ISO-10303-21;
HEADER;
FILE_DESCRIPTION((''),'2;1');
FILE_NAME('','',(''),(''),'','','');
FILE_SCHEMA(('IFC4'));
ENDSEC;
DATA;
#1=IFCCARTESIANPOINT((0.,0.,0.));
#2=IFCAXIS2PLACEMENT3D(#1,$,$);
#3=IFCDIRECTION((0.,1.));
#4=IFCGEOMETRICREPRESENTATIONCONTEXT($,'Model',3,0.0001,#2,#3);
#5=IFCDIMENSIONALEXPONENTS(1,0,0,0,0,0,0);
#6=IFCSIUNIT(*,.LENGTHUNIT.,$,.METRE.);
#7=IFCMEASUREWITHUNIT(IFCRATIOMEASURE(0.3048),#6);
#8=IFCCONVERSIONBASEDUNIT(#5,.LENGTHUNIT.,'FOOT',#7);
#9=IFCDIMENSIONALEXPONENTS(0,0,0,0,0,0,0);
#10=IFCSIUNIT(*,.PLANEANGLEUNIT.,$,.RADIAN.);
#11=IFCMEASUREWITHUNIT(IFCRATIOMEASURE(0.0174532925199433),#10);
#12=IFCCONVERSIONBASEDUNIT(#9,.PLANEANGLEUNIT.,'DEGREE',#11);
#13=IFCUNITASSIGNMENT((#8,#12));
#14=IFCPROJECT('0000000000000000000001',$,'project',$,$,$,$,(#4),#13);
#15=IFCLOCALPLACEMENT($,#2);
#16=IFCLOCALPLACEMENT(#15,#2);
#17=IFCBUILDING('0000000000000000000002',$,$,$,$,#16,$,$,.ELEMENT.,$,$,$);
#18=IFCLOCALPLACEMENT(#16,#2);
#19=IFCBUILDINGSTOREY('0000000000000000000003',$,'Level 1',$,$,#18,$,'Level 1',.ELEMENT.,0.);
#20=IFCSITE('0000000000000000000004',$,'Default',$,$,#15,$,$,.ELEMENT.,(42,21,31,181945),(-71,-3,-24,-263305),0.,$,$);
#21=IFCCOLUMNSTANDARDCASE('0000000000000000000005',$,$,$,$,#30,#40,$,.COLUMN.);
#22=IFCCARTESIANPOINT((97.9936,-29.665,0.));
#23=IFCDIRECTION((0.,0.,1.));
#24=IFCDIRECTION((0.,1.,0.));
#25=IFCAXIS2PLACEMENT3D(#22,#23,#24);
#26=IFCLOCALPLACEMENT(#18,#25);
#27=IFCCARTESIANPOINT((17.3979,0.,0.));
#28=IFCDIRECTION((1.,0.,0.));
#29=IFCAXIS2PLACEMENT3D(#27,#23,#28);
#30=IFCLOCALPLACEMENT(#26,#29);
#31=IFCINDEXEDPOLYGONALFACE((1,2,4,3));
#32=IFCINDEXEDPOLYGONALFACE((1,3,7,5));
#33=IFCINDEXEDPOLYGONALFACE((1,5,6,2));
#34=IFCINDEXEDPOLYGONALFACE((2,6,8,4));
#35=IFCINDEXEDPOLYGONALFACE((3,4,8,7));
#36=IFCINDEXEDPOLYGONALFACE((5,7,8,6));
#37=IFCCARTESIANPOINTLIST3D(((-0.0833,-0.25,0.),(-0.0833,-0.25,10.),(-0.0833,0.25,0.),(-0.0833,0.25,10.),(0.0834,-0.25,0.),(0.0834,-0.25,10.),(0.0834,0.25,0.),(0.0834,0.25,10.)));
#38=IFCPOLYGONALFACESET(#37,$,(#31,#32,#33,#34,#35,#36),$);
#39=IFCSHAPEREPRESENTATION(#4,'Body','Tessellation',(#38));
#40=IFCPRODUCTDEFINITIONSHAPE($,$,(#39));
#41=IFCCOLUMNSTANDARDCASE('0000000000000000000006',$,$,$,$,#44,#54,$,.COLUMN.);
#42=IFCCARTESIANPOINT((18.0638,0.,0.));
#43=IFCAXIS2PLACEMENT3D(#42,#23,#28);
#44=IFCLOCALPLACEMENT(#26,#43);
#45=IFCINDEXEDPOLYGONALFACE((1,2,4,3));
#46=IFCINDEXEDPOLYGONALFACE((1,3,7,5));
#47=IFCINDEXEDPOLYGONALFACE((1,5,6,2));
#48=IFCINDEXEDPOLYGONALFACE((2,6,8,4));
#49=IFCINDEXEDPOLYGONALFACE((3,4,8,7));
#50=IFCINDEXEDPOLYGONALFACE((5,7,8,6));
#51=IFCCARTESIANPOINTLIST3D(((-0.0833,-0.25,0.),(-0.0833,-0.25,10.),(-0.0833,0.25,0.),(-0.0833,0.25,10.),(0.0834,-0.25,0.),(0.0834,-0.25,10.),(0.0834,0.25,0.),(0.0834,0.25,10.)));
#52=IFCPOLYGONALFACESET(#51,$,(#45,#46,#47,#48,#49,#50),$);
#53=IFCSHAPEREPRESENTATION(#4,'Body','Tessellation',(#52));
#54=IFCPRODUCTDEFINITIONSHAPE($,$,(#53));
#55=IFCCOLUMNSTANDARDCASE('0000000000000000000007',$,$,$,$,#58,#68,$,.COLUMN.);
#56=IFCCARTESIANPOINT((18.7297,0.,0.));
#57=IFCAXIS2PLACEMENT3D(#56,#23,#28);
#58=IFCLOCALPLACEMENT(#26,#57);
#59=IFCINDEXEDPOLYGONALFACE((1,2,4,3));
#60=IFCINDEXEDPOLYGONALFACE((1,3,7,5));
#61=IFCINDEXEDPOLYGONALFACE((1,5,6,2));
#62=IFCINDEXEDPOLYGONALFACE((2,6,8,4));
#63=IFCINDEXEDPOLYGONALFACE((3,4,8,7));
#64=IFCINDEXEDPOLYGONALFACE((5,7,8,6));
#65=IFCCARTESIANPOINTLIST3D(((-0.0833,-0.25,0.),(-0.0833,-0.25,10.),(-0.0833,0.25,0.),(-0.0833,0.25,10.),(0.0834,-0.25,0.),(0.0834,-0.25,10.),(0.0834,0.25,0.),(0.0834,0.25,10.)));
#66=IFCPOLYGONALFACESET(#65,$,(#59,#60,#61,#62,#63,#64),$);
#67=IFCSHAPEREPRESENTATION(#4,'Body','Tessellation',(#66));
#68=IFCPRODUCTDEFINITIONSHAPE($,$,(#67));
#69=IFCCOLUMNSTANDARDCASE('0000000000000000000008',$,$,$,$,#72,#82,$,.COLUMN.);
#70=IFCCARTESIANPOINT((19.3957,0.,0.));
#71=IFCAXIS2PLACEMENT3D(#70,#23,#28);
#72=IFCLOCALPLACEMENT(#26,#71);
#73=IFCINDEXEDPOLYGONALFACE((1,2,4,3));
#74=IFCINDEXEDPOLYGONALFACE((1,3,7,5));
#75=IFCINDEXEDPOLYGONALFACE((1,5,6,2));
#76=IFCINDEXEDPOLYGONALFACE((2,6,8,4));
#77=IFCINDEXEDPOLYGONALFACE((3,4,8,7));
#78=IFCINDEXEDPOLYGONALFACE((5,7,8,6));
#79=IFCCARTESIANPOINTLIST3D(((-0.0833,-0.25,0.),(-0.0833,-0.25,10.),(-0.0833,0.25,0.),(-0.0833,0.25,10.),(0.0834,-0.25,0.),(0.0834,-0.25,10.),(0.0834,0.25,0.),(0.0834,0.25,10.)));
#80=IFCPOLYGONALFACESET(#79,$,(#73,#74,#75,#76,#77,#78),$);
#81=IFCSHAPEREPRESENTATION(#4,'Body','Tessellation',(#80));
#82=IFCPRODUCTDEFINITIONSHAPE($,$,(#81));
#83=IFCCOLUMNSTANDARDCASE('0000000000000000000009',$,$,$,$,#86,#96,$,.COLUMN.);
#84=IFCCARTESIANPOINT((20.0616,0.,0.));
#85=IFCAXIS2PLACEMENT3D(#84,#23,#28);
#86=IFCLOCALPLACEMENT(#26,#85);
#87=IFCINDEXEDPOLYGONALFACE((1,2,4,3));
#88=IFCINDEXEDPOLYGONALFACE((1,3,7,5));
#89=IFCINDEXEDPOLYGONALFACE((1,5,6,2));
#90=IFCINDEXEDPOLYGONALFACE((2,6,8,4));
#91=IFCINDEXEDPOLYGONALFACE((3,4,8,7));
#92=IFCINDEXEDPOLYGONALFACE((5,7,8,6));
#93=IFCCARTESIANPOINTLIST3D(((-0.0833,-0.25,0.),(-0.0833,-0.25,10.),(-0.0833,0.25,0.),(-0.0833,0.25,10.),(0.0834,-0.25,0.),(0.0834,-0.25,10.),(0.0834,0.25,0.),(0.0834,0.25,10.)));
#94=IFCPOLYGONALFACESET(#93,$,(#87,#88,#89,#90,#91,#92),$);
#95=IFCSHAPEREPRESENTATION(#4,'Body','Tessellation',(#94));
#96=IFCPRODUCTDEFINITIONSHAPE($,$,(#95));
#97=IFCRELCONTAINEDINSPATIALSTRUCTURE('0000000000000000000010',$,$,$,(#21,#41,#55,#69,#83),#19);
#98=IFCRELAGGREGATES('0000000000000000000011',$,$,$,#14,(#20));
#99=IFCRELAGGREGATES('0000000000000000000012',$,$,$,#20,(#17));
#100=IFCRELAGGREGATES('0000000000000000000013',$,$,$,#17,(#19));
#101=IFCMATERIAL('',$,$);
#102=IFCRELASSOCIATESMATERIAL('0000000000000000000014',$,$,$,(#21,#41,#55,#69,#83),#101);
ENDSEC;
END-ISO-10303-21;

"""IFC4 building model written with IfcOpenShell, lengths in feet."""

from ifc_helpers import new_model, entity, si_unit, converted_unit, direction, frame, origin, place, context, project, spatial, rectangle, extrude, material, element, save


model = new_model("IFC4")

# Units and contexts
model_context = context("Model", 3, precision=0.0001, world=origin(), true_north=direction((0.0, 1.0)))
ifc_project = project(units=[converted_unit("LENGTHUNIT", "FOOT", entity("IfcRatioMeasure", 0.3048), si_unit("LENGTHUNIT", "METRE"), dimensions=[1, 0, 0, 0, 0, 0, 0]), converted_unit("PLANEANGLEUNIT", "DEGREE", entity("IfcRatioMeasure", 0.0174532925199433), si_unit("PLANEANGLEUNIT", "RADIAN"), dimensions=[0, 0, 0, 0, 0, 0, 0])], contexts=[model_context])

# Site, building, storey
site_placement = place(None, origin())
site = spatial("IfcSite", under=ifc_project, at=site_placement, Name="Default", CompositionType="ELEMENT", RefLatitude=(42, 21, 31, 181945), RefLongitude=(-71, -3, -24, -263305), RefElevation=0.0)
building_placement = place(site_placement, origin())
building = spatial("IfcBuilding", under=site, at=building_placement, CompositionType="ELEMENT")
storey_placement = place(building_placement, origin())
storey = spatial("IfcBuildingStorey", under=building, at=storey_placement, Name="Level 1", LongName="Level 1", CompositionType="ELEMENT", Elevation=0.0)

# Columns
ifc_material = material(Name="")
placement = place(storey_placement, frame((97.9936, -29.665, 0.0), z_axis=(0.0, 0.0, 1.0), x_axis=(0.0, 1.0, 0.0)))
for number, where, z_axis, x_axis in (
    (1, (17.3979, 0.0, 0.0), (0.0, 0.0, 1.0), (1.0, 0.0, 0.0)),
    (2, (18.0638, 0.0, 0.0), (0.0, 0.0, 1.0), (1.0, 0.0, 0.0)),
    (3, (18.7297, 0.0, 0.0), (0.0, 0.0, 1.0), (1.0, 0.0, 0.0)),
    (4, (19.3957, 0.0, 0.0), (0.0, 0.0, 1.0), (1.0, 0.0, 0.0)),
    (5, (20.0616, 0.0, 0.0), (0.0, 0.0, 1.0), (1.0, 0.0, 0.0)),
):
    element("IfcColumnStandardCase", number, at=place(placement, frame(where, z_axis=z_axis, x_axis=x_axis)), inside=storey, material=ifc_material, PredefinedType="COLUMN", context=model_context, shape_type="SweptSolid", body=[
        extrude(rectangle(XDim=0.1667, YDim=0.5), origin(), (0.0, 0.0, 1.0), 10.0),
    ])

save(model, "model.ifc")
